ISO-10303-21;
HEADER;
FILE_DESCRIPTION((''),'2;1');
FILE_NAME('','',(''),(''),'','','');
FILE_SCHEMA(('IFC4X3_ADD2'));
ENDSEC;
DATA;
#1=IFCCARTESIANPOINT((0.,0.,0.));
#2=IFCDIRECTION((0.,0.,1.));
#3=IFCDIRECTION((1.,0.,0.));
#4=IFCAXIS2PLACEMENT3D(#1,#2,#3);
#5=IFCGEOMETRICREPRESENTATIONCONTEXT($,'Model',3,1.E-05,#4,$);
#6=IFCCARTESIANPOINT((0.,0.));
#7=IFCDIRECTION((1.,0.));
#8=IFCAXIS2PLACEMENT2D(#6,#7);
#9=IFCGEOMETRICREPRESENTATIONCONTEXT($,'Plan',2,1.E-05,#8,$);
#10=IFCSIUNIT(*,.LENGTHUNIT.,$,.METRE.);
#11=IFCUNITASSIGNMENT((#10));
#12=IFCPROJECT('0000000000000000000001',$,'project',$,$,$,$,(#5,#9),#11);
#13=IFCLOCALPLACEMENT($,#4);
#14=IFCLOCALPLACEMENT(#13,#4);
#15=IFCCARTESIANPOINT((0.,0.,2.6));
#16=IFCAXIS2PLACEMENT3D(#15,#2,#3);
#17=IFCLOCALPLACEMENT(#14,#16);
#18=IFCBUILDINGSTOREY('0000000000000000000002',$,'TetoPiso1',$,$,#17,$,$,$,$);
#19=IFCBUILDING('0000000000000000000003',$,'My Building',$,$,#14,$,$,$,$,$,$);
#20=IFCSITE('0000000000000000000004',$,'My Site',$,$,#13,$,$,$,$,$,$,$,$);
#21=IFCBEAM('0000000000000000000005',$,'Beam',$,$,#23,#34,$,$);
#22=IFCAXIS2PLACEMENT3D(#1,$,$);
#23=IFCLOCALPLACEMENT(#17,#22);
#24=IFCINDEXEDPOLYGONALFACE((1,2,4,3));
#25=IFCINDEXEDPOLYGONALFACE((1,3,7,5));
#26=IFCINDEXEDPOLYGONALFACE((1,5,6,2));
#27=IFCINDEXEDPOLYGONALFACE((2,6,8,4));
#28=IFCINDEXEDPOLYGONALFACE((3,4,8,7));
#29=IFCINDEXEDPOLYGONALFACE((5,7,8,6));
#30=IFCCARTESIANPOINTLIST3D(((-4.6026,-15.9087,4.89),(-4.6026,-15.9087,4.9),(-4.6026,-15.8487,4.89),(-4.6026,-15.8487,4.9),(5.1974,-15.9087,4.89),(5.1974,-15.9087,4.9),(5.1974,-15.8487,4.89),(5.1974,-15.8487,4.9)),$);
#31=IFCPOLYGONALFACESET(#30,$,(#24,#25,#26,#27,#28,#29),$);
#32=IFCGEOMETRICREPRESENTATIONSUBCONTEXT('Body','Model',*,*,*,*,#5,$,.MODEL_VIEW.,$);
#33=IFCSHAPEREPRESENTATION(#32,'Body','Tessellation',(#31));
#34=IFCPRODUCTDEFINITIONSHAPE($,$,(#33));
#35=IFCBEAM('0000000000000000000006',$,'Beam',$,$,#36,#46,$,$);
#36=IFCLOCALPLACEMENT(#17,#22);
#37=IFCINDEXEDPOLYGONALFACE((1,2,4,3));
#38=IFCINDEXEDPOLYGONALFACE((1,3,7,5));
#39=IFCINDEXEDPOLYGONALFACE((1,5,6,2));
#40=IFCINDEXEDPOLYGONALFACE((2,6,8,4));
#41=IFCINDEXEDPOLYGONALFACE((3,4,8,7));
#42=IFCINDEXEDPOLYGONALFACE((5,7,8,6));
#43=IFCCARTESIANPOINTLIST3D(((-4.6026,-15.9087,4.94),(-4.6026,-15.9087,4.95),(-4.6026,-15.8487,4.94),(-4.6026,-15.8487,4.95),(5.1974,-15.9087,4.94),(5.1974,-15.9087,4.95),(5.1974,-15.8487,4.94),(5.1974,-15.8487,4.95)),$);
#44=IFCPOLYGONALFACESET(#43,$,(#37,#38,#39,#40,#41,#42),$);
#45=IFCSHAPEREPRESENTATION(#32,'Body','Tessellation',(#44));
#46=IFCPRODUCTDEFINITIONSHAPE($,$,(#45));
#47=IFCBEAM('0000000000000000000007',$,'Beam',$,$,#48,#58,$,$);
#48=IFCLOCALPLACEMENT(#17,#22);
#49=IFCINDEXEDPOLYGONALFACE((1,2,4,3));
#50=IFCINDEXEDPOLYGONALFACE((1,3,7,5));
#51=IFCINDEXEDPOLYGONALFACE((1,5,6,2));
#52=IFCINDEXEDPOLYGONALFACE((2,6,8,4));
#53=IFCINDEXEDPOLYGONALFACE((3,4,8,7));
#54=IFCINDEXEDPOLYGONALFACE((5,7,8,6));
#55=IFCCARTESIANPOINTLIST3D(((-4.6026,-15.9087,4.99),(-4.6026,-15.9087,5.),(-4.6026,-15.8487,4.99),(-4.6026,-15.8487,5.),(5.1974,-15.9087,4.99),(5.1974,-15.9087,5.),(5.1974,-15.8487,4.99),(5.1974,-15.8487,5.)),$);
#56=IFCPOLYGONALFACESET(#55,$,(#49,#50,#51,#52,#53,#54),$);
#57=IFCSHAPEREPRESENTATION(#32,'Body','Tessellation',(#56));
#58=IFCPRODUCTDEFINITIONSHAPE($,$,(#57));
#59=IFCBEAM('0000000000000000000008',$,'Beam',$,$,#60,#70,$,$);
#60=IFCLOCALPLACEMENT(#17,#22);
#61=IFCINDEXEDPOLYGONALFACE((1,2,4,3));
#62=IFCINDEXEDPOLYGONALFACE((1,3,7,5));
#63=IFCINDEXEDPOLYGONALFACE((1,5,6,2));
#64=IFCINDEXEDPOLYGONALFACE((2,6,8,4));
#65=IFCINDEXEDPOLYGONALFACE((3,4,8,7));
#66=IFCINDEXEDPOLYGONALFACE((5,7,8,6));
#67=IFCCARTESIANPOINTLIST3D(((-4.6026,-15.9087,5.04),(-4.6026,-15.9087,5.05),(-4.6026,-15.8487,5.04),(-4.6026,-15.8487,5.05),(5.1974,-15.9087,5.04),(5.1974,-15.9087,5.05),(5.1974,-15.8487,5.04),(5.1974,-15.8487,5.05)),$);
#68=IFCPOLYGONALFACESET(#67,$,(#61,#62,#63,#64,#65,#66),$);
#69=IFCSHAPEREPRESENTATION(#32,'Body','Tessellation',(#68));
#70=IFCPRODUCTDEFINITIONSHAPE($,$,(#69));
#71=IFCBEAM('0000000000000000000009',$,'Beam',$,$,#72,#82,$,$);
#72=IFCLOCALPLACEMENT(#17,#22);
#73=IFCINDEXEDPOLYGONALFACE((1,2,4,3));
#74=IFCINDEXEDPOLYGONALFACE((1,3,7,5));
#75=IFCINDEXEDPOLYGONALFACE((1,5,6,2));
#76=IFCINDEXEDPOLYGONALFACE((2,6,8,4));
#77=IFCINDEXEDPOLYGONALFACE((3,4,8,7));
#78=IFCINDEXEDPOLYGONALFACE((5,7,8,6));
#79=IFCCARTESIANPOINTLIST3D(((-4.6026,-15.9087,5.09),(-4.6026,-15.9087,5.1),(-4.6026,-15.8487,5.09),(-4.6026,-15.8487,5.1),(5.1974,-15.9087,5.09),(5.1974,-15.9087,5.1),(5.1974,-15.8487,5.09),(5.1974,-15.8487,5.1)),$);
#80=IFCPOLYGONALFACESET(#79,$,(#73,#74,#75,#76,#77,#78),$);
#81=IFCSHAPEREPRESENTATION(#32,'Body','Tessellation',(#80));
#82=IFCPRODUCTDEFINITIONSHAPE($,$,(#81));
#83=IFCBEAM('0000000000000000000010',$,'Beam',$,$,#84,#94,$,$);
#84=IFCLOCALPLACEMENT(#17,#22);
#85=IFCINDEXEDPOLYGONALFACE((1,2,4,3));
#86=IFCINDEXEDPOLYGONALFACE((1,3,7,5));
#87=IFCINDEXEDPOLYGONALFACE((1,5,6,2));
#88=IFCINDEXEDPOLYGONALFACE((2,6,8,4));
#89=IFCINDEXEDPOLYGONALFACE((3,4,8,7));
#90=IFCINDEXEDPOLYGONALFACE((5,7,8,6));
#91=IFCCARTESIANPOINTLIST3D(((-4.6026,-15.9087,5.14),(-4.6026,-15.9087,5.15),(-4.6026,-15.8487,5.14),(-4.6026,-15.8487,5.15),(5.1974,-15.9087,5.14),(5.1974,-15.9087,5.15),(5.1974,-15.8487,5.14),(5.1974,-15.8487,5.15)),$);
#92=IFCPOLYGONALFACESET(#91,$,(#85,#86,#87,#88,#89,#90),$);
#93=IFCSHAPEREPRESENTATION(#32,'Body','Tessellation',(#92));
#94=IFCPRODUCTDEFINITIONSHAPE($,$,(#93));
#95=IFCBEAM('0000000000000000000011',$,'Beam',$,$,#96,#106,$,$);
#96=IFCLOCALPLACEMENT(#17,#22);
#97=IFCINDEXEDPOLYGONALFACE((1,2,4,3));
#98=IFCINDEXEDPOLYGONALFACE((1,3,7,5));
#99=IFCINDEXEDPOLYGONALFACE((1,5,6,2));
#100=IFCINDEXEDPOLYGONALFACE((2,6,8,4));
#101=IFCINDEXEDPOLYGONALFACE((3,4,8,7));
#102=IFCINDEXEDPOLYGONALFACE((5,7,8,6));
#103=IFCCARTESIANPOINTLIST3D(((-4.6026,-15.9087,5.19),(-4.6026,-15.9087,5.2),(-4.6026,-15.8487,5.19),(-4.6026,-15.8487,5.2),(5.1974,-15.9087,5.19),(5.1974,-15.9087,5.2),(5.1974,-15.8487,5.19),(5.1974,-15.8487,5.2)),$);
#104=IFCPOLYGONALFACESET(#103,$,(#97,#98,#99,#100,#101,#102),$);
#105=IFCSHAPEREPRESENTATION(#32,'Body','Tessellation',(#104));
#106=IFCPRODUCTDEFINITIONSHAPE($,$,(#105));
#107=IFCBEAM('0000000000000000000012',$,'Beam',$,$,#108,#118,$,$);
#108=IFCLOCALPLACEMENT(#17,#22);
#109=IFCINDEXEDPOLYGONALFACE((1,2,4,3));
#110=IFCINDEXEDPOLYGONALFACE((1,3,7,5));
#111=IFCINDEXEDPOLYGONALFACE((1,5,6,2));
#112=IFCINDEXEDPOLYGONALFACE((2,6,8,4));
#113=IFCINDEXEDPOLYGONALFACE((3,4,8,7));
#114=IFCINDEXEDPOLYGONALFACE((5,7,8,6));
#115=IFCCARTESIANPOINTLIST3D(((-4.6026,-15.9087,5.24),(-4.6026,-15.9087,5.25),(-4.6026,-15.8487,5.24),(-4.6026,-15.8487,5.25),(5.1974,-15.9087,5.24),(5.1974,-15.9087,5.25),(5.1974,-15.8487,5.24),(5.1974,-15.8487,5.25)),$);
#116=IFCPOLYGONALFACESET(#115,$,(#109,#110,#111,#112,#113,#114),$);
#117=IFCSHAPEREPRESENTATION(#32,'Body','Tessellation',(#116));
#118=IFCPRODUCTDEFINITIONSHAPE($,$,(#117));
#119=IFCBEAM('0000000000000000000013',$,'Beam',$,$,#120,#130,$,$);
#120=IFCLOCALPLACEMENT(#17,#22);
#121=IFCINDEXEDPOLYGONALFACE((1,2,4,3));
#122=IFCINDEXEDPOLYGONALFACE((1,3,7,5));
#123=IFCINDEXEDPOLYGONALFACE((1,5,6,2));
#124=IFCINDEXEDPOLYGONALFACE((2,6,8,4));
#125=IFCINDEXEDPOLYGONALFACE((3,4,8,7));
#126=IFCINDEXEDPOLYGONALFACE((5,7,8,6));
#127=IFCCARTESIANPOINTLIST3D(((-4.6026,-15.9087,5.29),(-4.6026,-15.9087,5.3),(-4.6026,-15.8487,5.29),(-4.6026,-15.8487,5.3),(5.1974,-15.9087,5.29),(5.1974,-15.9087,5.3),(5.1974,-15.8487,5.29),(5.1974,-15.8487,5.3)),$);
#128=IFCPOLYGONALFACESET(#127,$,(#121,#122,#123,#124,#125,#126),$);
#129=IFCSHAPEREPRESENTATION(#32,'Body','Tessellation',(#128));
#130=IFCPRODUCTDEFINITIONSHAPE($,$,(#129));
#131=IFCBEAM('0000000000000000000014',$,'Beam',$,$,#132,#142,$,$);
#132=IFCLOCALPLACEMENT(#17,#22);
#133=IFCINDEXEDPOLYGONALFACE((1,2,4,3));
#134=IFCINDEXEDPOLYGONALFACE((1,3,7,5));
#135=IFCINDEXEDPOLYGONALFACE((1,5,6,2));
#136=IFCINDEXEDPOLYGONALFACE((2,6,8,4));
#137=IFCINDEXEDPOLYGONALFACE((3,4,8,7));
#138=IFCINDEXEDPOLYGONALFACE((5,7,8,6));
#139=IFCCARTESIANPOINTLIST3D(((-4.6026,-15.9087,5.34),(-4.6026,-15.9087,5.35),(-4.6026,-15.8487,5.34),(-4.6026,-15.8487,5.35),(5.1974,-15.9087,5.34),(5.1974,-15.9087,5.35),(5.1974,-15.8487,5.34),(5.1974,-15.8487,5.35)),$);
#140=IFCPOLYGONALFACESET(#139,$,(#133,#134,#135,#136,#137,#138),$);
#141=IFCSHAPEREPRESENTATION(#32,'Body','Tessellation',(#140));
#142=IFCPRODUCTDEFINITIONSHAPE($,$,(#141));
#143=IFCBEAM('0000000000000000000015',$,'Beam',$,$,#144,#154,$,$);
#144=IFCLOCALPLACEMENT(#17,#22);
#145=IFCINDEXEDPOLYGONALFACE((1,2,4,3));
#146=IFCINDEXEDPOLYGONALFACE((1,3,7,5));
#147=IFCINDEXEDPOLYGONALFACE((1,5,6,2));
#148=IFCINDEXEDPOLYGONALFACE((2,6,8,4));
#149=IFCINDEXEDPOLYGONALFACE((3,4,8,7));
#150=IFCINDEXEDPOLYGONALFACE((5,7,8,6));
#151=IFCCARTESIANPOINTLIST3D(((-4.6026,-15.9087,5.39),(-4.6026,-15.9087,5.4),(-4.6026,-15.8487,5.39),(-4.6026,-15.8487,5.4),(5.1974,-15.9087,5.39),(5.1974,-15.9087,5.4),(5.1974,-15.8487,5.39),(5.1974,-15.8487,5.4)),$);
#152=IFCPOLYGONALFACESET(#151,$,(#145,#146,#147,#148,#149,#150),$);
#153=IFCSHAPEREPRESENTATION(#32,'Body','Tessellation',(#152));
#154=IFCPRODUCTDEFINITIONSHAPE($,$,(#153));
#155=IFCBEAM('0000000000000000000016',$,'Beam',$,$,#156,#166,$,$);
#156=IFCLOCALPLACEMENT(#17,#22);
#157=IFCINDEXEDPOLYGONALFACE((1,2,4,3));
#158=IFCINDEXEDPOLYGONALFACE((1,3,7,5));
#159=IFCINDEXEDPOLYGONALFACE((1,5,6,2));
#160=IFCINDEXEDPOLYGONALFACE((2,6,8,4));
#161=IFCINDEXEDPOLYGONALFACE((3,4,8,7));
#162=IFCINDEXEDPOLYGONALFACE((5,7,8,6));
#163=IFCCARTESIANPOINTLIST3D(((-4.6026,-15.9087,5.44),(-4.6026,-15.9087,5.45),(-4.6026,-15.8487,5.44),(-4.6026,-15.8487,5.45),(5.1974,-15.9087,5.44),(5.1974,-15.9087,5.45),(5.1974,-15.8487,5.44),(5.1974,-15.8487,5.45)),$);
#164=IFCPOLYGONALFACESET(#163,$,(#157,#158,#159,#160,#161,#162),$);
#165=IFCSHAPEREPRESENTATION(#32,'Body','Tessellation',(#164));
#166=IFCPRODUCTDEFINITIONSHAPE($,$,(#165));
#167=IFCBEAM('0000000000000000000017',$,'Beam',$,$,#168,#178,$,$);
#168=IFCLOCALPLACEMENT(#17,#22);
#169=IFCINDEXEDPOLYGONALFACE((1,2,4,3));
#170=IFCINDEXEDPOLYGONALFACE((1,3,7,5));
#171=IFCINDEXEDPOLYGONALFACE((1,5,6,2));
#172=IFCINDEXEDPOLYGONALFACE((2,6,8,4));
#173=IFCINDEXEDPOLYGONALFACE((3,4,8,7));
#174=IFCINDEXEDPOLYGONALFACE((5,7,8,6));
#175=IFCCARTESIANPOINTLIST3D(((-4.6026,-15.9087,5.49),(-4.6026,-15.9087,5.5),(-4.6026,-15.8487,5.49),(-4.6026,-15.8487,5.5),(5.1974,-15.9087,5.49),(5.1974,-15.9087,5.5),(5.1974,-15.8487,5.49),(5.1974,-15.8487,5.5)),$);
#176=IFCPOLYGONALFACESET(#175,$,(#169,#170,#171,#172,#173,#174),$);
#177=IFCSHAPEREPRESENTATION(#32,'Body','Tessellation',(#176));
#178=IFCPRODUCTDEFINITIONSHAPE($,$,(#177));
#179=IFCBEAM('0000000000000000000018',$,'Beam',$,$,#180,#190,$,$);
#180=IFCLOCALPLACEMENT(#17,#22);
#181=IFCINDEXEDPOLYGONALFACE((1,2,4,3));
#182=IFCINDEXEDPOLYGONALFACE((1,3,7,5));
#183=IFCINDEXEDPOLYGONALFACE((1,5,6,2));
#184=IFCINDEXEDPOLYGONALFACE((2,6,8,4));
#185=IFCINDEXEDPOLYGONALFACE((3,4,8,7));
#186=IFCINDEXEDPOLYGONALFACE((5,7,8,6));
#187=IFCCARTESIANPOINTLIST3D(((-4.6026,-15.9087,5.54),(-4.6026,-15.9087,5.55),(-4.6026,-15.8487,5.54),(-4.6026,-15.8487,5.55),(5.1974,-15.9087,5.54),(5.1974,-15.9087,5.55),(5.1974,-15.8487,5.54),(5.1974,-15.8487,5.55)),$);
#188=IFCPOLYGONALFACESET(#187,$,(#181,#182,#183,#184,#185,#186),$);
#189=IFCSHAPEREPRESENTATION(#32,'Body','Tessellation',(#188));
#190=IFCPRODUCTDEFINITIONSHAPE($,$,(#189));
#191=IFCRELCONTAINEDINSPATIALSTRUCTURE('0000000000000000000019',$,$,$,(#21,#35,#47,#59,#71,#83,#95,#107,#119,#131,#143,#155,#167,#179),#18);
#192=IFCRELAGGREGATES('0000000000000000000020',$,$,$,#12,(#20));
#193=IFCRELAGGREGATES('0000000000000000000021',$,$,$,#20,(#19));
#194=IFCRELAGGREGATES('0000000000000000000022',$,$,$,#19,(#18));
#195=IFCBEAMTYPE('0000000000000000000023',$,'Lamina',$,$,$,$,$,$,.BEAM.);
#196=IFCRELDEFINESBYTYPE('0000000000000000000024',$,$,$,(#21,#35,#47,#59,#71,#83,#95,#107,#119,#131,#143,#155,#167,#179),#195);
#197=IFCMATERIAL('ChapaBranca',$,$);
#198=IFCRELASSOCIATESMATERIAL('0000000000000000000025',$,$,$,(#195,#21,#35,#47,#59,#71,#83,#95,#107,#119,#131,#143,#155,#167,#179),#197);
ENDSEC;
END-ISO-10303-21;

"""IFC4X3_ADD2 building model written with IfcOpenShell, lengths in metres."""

from ifc_helpers import new_model, si_unit, frame, origin_with_axes, origin_2d, origin_2d_with_axis, place, context, subcontext, project, spatial, rectangle, extrude, material, material_profile, profile_set, profile_usage, type_object, element, save


model = new_model("IFC4X3_ADD2")

# Units and contexts
model_context = context("Model", 3, precision=1e-05, world=origin_with_axes())
plan_context = context("Plan", 2, precision=1e-05, world=origin_2d_with_axis())
body_context_1 = subcontext(model_context, "Body", "Model", "MODEL_VIEW")
ifc_project = project(units=[si_unit("LENGTHUNIT", "METRE")], contexts=[model_context, plan_context])

# Site, building, storey
site_placement = place(None, origin_with_axes())
site = spatial("IfcSite", under=ifc_project, at=site_placement, Name="My Site")
building_placement = place(site_placement, origin_with_axes())
building = spatial("IfcBuilding", under=site, at=building_placement, Name="My Building")
storey_placement = place(building_placement, frame((0.0, 0.0, 2.6), z_axis=(0.0, 0.0, 1.0), x_axis=(1.0, 0.0, 0.0)))
storey = spatial("IfcBuildingStorey", under=building, at=storey_placement, Name="TetoPiso1")

# Beams
ifc_material_1 = material(Name="ChapaBranca")
ifc_material_profile_1 = material_profile(ifc_material_1, rectangle(XDim=0.06, YDim=0.01, at=origin_2d()))
ifc_profile_set_1 = profile_set([ifc_material_profile_1])
beam_type_1 = type_object("IfcBeamType", Name="Lamina", PredefinedType="BEAM", material=ifc_profile_set_1)
ifc_profile_usage_1 = profile_usage(ifc_profile_set_1, cardinal=5)
beam_1_placement = place(storey_placement, frame((-4.6026, -15.8787, 4.895), z_axis=(1.0, 0.0, 0.0), x_axis=(0.0, 1.0, 0.0)))
element("IfcBeam", 1, at=beam_1_placement, inside=storey, type_object=beam_type_1, material=ifc_profile_usage_1, Name="Beam", context=body_context_1, shape_type="SweptSolid", body=[
    extrude(rectangle(XDim=0.06, YDim=0.01, at=origin_2d()), origin_with_axes(), (0.0, 0.0, 1.0), 9.8),
])
ifc_profile_usage_2 = profile_usage(ifc_profile_set_1, cardinal=5)
beam_2_placement = place(storey_placement, frame((-4.6026, -15.8787, 4.945), z_axis=(1.0, 0.0, 0.0), x_axis=(0.0, 1.0, 0.0)))
element("IfcBeam", 2, at=beam_2_placement, inside=storey, type_object=beam_type_1, material=ifc_profile_usage_2, Name="Beam", context=body_context_1, shape_type="SweptSolid", body=[
    extrude(rectangle(XDim=0.06, YDim=0.01, at=origin_2d()), origin_with_axes(), (0.0, 0.0, 1.0), 9.8),
])
ifc_profile_usage_3 = profile_usage(ifc_profile_set_1, cardinal=5)
beam_3_placement = place(storey_placement, frame((-4.6026, -15.8787, 4.995), z_axis=(1.0, 0.0, 0.0), x_axis=(0.0, 1.0, 0.0)))
element("IfcBeam", 3, at=beam_3_placement, inside=storey, type_object=beam_type_1, material=ifc_profile_usage_3, Name="Beam", context=body_context_1, shape_type="SweptSolid", body=[
    extrude(rectangle(XDim=0.06, YDim=0.01, at=origin_2d()), origin_with_axes(), (0.0, 0.0, 1.0), 9.8),
])
ifc_profile_usage_4 = profile_usage(ifc_profile_set_1, cardinal=5)
beam_4_placement = place(storey_placement, frame((-4.6026, -15.8787, 5.045), z_axis=(1.0, 0.0, 0.0), x_axis=(0.0, 1.0, 0.0)))
element("IfcBeam", 4, at=beam_4_placement, inside=storey, type_object=beam_type_1, material=ifc_profile_usage_4, Name="Beam", context=body_context_1, shape_type="SweptSolid", body=[
    extrude(rectangle(XDim=0.06, YDim=0.01, at=origin_2d()), origin_with_axes(), (0.0, 0.0, 1.0), 9.8),
])
ifc_profile_usage_5 = profile_usage(ifc_profile_set_1, cardinal=5)
beam_5_placement = place(storey_placement, frame((-4.6026, -15.8787, 5.095), z_axis=(1.0, 0.0, 0.0), x_axis=(0.0, 1.0, 0.0)))
element("IfcBeam", 5, at=beam_5_placement, inside=storey, type_object=beam_type_1, material=ifc_profile_usage_5, Name="Beam", context=body_context_1, shape_type="SweptSolid", body=[
    extrude(rectangle(XDim=0.06, YDim=0.01, at=origin_2d()), origin_with_axes(), (0.0, 0.0, 1.0), 9.8),
])
ifc_profile_usage_6 = profile_usage(ifc_profile_set_1, cardinal=5)
beam_6_placement = place(storey_placement, frame((-4.6026, -15.8787, 5.145), z_axis=(1.0, 0.0, 0.0), x_axis=(0.0, 1.0, 0.0)))
element("IfcBeam", 6, at=beam_6_placement, inside=storey, type_object=beam_type_1, material=ifc_profile_usage_6, Name="Beam", context=body_context_1, shape_type="SweptSolid", body=[
    extrude(rectangle(XDim=0.06, YDim=0.01, at=origin_2d()), origin_with_axes(), (0.0, 0.0, 1.0), 9.8),
])
ifc_profile_usage_7 = profile_usage(ifc_profile_set_1, cardinal=5)
beam_7_placement = place(storey_placement, frame((-4.6026, -15.8787, 5.195), z_axis=(1.0, 0.0, 0.0), x_axis=(0.0, 1.0, 0.0)))
element("IfcBeam", 7, at=beam_7_placement, inside=storey, type_object=beam_type_1, material=ifc_profile_usage_7, Name="Beam", context=body_context_1, shape_type="SweptSolid", body=[
    extrude(rectangle(XDim=0.06, YDim=0.01, at=origin_2d()), origin_with_axes(), (0.0, 0.0, 1.0), 9.8),
])
ifc_profile_usage_8 = profile_usage(ifc_profile_set_1, cardinal=5)
beam_8_placement = place(storey_placement, frame((-4.6026, -15.8787, 5.245), z_axis=(1.0, 0.0, 0.0), x_axis=(0.0, 1.0, 0.0)))
element("IfcBeam", 8, at=beam_8_placement, inside=storey, type_object=beam_type_1, material=ifc_profile_usage_8, Name="Beam", context=body_context_1, shape_type="SweptSolid", body=[
    extrude(rectangle(XDim=0.06, YDim=0.01, at=origin_2d()), origin_with_axes(), (0.0, 0.0, 1.0), 9.8),
])
ifc_profile_usage_9 = profile_usage(ifc_profile_set_1, cardinal=5)
beam_9_placement = place(storey_placement, frame((-4.6026, -15.8787, 5.295), z_axis=(1.0, 0.0, 0.0), x_axis=(0.0, 1.0, 0.0)))
element("IfcBeam", 9, at=beam_9_placement, inside=storey, type_object=beam_type_1, material=ifc_profile_usage_9, Name="Beam", context=body_context_1, shape_type="SweptSolid", body=[
    extrude(rectangle(XDim=0.06, YDim=0.01, at=origin_2d()), origin_with_axes(), (0.0, 0.0, 1.0), 9.8),
])
ifc_profile_usage_10 = profile_usage(ifc_profile_set_1, cardinal=5)
beam_10_placement = place(storey_placement, frame((-4.6026, -15.8787, 5.345), z_axis=(1.0, 0.0, 0.0), x_axis=(0.0, 1.0, 0.0)))
element("IfcBeam", 10, at=beam_10_placement, inside=storey, type_object=beam_type_1, material=ifc_profile_usage_10, Name="Beam", context=body_context_1, shape_type="SweptSolid", body=[
    extrude(rectangle(XDim=0.06, YDim=0.01, at=origin_2d()), origin_with_axes(), (0.0, 0.0, 1.0), 9.8),
])
ifc_profile_usage_11 = profile_usage(ifc_profile_set_1, cardinal=5)
beam_11_placement = place(storey_placement, frame((-4.6026, -15.8787, 5.395), z_axis=(1.0, 0.0, 0.0), x_axis=(0.0, 1.0, 0.0)))
element("IfcBeam", 11, at=beam_11_placement, inside=storey, type_object=beam_type_1, material=ifc_profile_usage_11, Name="Beam", context=body_context_1, shape_type="SweptSolid", body=[
    extrude(rectangle(XDim=0.06, YDim=0.01, at=origin_2d()), origin_with_axes(), (0.0, 0.0, 1.0), 9.8),
])
ifc_profile_usage_12 = profile_usage(ifc_profile_set_1, cardinal=5)
beam_12_placement = place(storey_placement, frame((-4.6026, -15.8787, 5.445), z_axis=(1.0, 0.0, 0.0), x_axis=(0.0, 1.0, 0.0)))
element("IfcBeam", 12, at=beam_12_placement, inside=storey, type_object=beam_type_1, material=ifc_profile_usage_12, Name="Beam", context=body_context_1, shape_type="SweptSolid", body=[
    extrude(rectangle(XDim=0.06, YDim=0.01, at=origin_2d()), origin_with_axes(), (0.0, 0.0, 1.0), 9.8),
])
ifc_profile_usage_13 = profile_usage(ifc_profile_set_1, cardinal=5)
beam_13_placement = place(storey_placement, frame((-4.6026, -15.8787, 5.495), z_axis=(1.0, 0.0, 0.0), x_axis=(0.0, 1.0, 0.0)))
element("IfcBeam", 13, at=beam_13_placement, inside=storey, type_object=beam_type_1, material=ifc_profile_usage_13, Name="Beam", context=body_context_1, shape_type="SweptSolid", body=[
    extrude(rectangle(XDim=0.06, YDim=0.01, at=origin_2d()), origin_with_axes(), (0.0, 0.0, 1.0), 9.8),
])
ifc_profile_usage_14 = profile_usage(ifc_profile_set_1, cardinal=5)
beam_14_placement = place(storey_placement, frame((-4.6026, -15.8787, 5.545), z_axis=(1.0, 0.0, 0.0), x_axis=(0.0, 1.0, 0.0)))
element("IfcBeam", 14, at=beam_14_placement, inside=storey, type_object=beam_type_1, material=ifc_profile_usage_14, Name="Beam", context=body_context_1, shape_type="SweptSolid", body=[
    extrude(rectangle(XDim=0.06, YDim=0.01, at=origin_2d()), origin_with_axes(), (0.0, 0.0, 1.0), 9.8),
])

save(model, "model.ifc")
